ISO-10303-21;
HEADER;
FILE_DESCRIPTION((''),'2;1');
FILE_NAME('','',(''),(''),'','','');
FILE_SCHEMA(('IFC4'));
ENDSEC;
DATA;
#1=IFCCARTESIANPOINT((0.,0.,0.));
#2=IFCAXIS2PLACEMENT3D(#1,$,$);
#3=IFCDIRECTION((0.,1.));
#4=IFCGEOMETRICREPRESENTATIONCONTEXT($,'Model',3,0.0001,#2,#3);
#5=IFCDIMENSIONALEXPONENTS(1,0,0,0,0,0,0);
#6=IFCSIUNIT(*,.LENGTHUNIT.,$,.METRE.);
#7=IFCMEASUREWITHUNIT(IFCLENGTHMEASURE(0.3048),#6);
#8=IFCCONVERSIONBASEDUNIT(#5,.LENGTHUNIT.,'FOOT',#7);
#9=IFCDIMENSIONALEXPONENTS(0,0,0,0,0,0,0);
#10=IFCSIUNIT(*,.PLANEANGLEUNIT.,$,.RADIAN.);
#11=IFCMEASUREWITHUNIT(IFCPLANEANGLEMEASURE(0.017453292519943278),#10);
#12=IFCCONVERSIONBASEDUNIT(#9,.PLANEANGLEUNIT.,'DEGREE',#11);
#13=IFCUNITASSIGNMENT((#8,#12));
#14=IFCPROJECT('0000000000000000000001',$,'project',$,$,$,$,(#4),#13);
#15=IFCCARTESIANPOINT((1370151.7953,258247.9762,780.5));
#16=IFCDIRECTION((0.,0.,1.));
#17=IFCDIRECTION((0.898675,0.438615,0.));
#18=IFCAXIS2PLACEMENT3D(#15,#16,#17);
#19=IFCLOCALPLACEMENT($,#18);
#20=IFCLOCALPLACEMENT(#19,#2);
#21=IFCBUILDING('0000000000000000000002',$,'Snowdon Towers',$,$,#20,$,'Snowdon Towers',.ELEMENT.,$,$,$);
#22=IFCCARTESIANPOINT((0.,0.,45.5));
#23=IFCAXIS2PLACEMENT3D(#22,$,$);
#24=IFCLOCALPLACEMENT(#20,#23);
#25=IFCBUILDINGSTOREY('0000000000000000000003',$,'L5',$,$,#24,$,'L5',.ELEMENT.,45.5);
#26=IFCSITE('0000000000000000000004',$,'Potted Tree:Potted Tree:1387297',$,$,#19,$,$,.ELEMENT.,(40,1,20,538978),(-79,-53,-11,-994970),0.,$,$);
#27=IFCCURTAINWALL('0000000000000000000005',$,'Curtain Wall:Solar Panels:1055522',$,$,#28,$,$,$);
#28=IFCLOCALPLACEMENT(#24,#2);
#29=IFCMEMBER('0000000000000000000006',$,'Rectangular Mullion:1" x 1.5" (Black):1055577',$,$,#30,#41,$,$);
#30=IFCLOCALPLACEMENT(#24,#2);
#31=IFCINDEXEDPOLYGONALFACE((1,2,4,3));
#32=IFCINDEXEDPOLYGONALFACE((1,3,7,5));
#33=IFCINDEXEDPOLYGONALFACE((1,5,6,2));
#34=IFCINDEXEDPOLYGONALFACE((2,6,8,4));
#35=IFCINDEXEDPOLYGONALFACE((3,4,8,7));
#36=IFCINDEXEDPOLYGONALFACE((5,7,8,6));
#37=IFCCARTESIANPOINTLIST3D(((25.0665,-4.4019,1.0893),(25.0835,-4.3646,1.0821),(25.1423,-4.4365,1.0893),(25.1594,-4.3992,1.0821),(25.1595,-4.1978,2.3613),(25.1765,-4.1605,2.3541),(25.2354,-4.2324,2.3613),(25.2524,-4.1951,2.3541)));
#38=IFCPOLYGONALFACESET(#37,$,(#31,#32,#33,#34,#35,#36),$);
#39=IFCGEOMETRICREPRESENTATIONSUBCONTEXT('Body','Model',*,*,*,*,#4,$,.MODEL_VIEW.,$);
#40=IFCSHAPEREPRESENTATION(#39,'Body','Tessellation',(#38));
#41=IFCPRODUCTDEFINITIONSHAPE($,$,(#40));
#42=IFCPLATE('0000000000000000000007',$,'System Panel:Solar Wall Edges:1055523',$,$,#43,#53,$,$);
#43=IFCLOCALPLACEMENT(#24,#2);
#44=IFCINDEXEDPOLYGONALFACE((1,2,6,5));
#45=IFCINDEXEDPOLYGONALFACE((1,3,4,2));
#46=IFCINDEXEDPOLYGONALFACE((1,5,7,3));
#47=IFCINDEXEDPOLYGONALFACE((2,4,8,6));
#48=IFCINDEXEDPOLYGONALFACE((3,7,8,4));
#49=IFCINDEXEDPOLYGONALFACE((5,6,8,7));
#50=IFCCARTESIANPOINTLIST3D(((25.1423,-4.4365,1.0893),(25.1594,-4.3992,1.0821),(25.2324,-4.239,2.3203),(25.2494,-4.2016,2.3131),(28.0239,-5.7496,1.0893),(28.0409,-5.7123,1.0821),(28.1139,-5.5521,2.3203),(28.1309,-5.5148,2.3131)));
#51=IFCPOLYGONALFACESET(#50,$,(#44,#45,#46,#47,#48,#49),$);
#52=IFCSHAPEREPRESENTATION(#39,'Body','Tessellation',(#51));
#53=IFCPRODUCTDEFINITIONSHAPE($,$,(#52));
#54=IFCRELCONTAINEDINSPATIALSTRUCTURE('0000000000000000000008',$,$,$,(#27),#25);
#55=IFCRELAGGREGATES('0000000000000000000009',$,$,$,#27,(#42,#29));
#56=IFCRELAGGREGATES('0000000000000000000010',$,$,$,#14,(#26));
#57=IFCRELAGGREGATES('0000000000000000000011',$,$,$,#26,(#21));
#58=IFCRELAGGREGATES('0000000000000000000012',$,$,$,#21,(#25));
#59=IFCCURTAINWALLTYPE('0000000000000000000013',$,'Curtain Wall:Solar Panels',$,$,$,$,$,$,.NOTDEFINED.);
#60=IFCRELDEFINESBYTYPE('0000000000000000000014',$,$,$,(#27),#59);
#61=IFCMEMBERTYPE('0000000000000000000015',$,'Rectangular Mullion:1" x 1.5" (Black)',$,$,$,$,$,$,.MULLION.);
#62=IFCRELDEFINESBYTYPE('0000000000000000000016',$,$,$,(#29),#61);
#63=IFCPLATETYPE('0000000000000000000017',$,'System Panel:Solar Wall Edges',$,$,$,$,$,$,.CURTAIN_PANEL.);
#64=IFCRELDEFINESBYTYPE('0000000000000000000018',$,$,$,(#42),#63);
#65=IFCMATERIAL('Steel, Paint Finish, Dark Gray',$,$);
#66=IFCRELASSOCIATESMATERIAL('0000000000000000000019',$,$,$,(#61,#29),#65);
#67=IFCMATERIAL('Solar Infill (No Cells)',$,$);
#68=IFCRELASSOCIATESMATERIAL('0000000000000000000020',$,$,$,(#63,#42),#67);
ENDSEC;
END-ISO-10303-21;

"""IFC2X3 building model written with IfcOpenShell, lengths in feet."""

from ifc_helpers import new_model, entity, si_unit, converted_unit, direction, frame, frame_2d, origin, origin_2d_with_axis, place, context, subcontext, project, spatial, rectangle, extrude, source, transform, mapped, material, type_object, type_shapes, element, aggregate, save


model = new_model("IFC2X3")

# Units and contexts
model_context = context("Model", 3, precision=0.0001, world=origin(), true_north=direction((0.0, 1.0)))
body_context = subcontext(model_context, "Body", "Model", "MODEL_VIEW")
ifc_project = project(units=[converted_unit("LENGTHUNIT", "FOOT", entity("IfcLengthMeasure", 0.3048), si_unit("LENGTHUNIT", "METRE"), dimensions=[1, 0, 0, 0, 0, 0, 0]), converted_unit("PLANEANGLEUNIT", "DEGREE", entity("IfcPlaneAngleMeasure", 0.017453292519943278), si_unit("PLANEANGLEUNIT", "RADIAN"), dimensions=[0, 0, 0, 0, 0, 0, 0])], contexts=[model_context])

# Site, building, storey
site_placement = place(None, frame((1370151.7953, 258247.9762, 780.5), z_axis=(0.0, 0.0, 1.0), x_axis=(0.898675, 0.438615, 0.0)))
site = spatial("IfcSite", under=ifc_project, at=site_placement, Name="Potted Tree:Potted Tree:1387297", CompositionType="ELEMENT", RefLatitude=(40, 1, 20, 538978), RefLongitude=(-79, -53, -11, -994970), RefElevation=0.0)
building_placement = place(site_placement, origin())
building = spatial("IfcBuilding", under=site, at=building_placement, Name="Snowdon Towers", LongName="Snowdon Towers", CompositionType="ELEMENT")
storey_placement = place(building_placement, frame((0.0, 0.0, 45.5)))
storey = spatial("IfcBuildingStorey", under=building, at=storey_placement, Name="L5", LongName="L5", CompositionType="ELEMENT", Elevation=45.5)

# Shared definitions
curtain_wall_type = type_object("IfcCurtainWallType", Name="Curtain Wall:Solar Panels", PredefinedType="NOTDEFINED")

# Curtain wall
curtain_wall_1_placement = place(storey_placement, frame((0.0, 0.0, -45.5)))
curtain_wall_1 = element("IfcCurtainWall", 1, at=curtain_wall_1_placement, inside=storey, type_object=curtain_wall_type, Name="Curtain Wall:Solar Panels:1055522")

# Member
ifc_material_1 = material(Name="Steel, Paint Finish, Dark Gray")
member_type_1 = type_object("IfcMemberType", Name="Rectangular Mullion:1\" x 1.5\" (Black)", PredefinedType="MULLION", material=ifc_material_1)
shared_shape_1 = source(origin(), body_context, "Body", "SweptSolid", [
    extrude(rectangle(XDim=0.0833, YDim=0.0417, at=origin_2d_with_axis()), frame((-0.0417, 0.0208, -1.2917), z_axis=(0.0, 0.0, 1.0), x_axis=(-1.0, 0.0, 0.0)), (0.0, 0.0, 1.0), 1.2917),
])
type_shapes(member_type_1, [shared_shape_1])
member_1_placement = place(curtain_wall_1_placement, frame((25.1765, -4.1605, 47.8541), z_axis=(0.072007, 0.158015, 0.984808), x_axis=(-0.909972, 0.414671, 0.0)))
member_1 = element("IfcMember", 2, at=member_1_placement, type_object=member_type_1, material=ifc_material_1, Name="Rectangular Mullion:1\" x 1.5\" (Black):1055577", context=body_context, shape_type="MappedRepresentation", body=[
    mapped(shared_shape_1, transform((0.0, 0.0, 0.0), scale=1.0)),
])

# Plate
ifc_material_2 = material(Name="Solar Infill (No Cells)")
plate_type_1 = type_object("IfcPlateType", Name="System Panel:Solar Wall Edges", PredefinedType="CURTAIN_PANEL", material=ifc_material_2)
shared_shape_2 = source(origin(), body_context, "Body", "SweptSolid", [
    extrude(rectangle(XDim=0.0417, YDim=3.1667, at=frame_2d((0.0, 0.0), x_axis=(1.0, 0.0))), frame((0.0, -0.0208, 0.0), z_axis=(0.0, 0.0, 1.0), x_axis=(0.0, 1.0, 0.0)), (0.0, 0.0, 1.0), 1.25),
])
type_shapes(plate_type_1, [shared_shape_2])
plate_1_placement = place(curtain_wall_1_placement, frame((26.6001, -5.0557, 46.5821), z_axis=(0.072007, 0.158015, 0.984808), x_axis=(0.909972, -0.414671, 0.0)))
plate_1 = element("IfcPlate", 3, at=plate_1_placement, type_object=plate_type_1, material=ifc_material_2, Name="System Panel:Solar Wall Edges:1055523", context=body_context, shape_type="MappedRepresentation", body=[
    mapped(shared_shape_2, transform((0.0, 0.0, 0.0), scale=1.0)),
])
aggregate(curtain_wall_1, [plate_1, member_1])

save(model, "model.ifc")
